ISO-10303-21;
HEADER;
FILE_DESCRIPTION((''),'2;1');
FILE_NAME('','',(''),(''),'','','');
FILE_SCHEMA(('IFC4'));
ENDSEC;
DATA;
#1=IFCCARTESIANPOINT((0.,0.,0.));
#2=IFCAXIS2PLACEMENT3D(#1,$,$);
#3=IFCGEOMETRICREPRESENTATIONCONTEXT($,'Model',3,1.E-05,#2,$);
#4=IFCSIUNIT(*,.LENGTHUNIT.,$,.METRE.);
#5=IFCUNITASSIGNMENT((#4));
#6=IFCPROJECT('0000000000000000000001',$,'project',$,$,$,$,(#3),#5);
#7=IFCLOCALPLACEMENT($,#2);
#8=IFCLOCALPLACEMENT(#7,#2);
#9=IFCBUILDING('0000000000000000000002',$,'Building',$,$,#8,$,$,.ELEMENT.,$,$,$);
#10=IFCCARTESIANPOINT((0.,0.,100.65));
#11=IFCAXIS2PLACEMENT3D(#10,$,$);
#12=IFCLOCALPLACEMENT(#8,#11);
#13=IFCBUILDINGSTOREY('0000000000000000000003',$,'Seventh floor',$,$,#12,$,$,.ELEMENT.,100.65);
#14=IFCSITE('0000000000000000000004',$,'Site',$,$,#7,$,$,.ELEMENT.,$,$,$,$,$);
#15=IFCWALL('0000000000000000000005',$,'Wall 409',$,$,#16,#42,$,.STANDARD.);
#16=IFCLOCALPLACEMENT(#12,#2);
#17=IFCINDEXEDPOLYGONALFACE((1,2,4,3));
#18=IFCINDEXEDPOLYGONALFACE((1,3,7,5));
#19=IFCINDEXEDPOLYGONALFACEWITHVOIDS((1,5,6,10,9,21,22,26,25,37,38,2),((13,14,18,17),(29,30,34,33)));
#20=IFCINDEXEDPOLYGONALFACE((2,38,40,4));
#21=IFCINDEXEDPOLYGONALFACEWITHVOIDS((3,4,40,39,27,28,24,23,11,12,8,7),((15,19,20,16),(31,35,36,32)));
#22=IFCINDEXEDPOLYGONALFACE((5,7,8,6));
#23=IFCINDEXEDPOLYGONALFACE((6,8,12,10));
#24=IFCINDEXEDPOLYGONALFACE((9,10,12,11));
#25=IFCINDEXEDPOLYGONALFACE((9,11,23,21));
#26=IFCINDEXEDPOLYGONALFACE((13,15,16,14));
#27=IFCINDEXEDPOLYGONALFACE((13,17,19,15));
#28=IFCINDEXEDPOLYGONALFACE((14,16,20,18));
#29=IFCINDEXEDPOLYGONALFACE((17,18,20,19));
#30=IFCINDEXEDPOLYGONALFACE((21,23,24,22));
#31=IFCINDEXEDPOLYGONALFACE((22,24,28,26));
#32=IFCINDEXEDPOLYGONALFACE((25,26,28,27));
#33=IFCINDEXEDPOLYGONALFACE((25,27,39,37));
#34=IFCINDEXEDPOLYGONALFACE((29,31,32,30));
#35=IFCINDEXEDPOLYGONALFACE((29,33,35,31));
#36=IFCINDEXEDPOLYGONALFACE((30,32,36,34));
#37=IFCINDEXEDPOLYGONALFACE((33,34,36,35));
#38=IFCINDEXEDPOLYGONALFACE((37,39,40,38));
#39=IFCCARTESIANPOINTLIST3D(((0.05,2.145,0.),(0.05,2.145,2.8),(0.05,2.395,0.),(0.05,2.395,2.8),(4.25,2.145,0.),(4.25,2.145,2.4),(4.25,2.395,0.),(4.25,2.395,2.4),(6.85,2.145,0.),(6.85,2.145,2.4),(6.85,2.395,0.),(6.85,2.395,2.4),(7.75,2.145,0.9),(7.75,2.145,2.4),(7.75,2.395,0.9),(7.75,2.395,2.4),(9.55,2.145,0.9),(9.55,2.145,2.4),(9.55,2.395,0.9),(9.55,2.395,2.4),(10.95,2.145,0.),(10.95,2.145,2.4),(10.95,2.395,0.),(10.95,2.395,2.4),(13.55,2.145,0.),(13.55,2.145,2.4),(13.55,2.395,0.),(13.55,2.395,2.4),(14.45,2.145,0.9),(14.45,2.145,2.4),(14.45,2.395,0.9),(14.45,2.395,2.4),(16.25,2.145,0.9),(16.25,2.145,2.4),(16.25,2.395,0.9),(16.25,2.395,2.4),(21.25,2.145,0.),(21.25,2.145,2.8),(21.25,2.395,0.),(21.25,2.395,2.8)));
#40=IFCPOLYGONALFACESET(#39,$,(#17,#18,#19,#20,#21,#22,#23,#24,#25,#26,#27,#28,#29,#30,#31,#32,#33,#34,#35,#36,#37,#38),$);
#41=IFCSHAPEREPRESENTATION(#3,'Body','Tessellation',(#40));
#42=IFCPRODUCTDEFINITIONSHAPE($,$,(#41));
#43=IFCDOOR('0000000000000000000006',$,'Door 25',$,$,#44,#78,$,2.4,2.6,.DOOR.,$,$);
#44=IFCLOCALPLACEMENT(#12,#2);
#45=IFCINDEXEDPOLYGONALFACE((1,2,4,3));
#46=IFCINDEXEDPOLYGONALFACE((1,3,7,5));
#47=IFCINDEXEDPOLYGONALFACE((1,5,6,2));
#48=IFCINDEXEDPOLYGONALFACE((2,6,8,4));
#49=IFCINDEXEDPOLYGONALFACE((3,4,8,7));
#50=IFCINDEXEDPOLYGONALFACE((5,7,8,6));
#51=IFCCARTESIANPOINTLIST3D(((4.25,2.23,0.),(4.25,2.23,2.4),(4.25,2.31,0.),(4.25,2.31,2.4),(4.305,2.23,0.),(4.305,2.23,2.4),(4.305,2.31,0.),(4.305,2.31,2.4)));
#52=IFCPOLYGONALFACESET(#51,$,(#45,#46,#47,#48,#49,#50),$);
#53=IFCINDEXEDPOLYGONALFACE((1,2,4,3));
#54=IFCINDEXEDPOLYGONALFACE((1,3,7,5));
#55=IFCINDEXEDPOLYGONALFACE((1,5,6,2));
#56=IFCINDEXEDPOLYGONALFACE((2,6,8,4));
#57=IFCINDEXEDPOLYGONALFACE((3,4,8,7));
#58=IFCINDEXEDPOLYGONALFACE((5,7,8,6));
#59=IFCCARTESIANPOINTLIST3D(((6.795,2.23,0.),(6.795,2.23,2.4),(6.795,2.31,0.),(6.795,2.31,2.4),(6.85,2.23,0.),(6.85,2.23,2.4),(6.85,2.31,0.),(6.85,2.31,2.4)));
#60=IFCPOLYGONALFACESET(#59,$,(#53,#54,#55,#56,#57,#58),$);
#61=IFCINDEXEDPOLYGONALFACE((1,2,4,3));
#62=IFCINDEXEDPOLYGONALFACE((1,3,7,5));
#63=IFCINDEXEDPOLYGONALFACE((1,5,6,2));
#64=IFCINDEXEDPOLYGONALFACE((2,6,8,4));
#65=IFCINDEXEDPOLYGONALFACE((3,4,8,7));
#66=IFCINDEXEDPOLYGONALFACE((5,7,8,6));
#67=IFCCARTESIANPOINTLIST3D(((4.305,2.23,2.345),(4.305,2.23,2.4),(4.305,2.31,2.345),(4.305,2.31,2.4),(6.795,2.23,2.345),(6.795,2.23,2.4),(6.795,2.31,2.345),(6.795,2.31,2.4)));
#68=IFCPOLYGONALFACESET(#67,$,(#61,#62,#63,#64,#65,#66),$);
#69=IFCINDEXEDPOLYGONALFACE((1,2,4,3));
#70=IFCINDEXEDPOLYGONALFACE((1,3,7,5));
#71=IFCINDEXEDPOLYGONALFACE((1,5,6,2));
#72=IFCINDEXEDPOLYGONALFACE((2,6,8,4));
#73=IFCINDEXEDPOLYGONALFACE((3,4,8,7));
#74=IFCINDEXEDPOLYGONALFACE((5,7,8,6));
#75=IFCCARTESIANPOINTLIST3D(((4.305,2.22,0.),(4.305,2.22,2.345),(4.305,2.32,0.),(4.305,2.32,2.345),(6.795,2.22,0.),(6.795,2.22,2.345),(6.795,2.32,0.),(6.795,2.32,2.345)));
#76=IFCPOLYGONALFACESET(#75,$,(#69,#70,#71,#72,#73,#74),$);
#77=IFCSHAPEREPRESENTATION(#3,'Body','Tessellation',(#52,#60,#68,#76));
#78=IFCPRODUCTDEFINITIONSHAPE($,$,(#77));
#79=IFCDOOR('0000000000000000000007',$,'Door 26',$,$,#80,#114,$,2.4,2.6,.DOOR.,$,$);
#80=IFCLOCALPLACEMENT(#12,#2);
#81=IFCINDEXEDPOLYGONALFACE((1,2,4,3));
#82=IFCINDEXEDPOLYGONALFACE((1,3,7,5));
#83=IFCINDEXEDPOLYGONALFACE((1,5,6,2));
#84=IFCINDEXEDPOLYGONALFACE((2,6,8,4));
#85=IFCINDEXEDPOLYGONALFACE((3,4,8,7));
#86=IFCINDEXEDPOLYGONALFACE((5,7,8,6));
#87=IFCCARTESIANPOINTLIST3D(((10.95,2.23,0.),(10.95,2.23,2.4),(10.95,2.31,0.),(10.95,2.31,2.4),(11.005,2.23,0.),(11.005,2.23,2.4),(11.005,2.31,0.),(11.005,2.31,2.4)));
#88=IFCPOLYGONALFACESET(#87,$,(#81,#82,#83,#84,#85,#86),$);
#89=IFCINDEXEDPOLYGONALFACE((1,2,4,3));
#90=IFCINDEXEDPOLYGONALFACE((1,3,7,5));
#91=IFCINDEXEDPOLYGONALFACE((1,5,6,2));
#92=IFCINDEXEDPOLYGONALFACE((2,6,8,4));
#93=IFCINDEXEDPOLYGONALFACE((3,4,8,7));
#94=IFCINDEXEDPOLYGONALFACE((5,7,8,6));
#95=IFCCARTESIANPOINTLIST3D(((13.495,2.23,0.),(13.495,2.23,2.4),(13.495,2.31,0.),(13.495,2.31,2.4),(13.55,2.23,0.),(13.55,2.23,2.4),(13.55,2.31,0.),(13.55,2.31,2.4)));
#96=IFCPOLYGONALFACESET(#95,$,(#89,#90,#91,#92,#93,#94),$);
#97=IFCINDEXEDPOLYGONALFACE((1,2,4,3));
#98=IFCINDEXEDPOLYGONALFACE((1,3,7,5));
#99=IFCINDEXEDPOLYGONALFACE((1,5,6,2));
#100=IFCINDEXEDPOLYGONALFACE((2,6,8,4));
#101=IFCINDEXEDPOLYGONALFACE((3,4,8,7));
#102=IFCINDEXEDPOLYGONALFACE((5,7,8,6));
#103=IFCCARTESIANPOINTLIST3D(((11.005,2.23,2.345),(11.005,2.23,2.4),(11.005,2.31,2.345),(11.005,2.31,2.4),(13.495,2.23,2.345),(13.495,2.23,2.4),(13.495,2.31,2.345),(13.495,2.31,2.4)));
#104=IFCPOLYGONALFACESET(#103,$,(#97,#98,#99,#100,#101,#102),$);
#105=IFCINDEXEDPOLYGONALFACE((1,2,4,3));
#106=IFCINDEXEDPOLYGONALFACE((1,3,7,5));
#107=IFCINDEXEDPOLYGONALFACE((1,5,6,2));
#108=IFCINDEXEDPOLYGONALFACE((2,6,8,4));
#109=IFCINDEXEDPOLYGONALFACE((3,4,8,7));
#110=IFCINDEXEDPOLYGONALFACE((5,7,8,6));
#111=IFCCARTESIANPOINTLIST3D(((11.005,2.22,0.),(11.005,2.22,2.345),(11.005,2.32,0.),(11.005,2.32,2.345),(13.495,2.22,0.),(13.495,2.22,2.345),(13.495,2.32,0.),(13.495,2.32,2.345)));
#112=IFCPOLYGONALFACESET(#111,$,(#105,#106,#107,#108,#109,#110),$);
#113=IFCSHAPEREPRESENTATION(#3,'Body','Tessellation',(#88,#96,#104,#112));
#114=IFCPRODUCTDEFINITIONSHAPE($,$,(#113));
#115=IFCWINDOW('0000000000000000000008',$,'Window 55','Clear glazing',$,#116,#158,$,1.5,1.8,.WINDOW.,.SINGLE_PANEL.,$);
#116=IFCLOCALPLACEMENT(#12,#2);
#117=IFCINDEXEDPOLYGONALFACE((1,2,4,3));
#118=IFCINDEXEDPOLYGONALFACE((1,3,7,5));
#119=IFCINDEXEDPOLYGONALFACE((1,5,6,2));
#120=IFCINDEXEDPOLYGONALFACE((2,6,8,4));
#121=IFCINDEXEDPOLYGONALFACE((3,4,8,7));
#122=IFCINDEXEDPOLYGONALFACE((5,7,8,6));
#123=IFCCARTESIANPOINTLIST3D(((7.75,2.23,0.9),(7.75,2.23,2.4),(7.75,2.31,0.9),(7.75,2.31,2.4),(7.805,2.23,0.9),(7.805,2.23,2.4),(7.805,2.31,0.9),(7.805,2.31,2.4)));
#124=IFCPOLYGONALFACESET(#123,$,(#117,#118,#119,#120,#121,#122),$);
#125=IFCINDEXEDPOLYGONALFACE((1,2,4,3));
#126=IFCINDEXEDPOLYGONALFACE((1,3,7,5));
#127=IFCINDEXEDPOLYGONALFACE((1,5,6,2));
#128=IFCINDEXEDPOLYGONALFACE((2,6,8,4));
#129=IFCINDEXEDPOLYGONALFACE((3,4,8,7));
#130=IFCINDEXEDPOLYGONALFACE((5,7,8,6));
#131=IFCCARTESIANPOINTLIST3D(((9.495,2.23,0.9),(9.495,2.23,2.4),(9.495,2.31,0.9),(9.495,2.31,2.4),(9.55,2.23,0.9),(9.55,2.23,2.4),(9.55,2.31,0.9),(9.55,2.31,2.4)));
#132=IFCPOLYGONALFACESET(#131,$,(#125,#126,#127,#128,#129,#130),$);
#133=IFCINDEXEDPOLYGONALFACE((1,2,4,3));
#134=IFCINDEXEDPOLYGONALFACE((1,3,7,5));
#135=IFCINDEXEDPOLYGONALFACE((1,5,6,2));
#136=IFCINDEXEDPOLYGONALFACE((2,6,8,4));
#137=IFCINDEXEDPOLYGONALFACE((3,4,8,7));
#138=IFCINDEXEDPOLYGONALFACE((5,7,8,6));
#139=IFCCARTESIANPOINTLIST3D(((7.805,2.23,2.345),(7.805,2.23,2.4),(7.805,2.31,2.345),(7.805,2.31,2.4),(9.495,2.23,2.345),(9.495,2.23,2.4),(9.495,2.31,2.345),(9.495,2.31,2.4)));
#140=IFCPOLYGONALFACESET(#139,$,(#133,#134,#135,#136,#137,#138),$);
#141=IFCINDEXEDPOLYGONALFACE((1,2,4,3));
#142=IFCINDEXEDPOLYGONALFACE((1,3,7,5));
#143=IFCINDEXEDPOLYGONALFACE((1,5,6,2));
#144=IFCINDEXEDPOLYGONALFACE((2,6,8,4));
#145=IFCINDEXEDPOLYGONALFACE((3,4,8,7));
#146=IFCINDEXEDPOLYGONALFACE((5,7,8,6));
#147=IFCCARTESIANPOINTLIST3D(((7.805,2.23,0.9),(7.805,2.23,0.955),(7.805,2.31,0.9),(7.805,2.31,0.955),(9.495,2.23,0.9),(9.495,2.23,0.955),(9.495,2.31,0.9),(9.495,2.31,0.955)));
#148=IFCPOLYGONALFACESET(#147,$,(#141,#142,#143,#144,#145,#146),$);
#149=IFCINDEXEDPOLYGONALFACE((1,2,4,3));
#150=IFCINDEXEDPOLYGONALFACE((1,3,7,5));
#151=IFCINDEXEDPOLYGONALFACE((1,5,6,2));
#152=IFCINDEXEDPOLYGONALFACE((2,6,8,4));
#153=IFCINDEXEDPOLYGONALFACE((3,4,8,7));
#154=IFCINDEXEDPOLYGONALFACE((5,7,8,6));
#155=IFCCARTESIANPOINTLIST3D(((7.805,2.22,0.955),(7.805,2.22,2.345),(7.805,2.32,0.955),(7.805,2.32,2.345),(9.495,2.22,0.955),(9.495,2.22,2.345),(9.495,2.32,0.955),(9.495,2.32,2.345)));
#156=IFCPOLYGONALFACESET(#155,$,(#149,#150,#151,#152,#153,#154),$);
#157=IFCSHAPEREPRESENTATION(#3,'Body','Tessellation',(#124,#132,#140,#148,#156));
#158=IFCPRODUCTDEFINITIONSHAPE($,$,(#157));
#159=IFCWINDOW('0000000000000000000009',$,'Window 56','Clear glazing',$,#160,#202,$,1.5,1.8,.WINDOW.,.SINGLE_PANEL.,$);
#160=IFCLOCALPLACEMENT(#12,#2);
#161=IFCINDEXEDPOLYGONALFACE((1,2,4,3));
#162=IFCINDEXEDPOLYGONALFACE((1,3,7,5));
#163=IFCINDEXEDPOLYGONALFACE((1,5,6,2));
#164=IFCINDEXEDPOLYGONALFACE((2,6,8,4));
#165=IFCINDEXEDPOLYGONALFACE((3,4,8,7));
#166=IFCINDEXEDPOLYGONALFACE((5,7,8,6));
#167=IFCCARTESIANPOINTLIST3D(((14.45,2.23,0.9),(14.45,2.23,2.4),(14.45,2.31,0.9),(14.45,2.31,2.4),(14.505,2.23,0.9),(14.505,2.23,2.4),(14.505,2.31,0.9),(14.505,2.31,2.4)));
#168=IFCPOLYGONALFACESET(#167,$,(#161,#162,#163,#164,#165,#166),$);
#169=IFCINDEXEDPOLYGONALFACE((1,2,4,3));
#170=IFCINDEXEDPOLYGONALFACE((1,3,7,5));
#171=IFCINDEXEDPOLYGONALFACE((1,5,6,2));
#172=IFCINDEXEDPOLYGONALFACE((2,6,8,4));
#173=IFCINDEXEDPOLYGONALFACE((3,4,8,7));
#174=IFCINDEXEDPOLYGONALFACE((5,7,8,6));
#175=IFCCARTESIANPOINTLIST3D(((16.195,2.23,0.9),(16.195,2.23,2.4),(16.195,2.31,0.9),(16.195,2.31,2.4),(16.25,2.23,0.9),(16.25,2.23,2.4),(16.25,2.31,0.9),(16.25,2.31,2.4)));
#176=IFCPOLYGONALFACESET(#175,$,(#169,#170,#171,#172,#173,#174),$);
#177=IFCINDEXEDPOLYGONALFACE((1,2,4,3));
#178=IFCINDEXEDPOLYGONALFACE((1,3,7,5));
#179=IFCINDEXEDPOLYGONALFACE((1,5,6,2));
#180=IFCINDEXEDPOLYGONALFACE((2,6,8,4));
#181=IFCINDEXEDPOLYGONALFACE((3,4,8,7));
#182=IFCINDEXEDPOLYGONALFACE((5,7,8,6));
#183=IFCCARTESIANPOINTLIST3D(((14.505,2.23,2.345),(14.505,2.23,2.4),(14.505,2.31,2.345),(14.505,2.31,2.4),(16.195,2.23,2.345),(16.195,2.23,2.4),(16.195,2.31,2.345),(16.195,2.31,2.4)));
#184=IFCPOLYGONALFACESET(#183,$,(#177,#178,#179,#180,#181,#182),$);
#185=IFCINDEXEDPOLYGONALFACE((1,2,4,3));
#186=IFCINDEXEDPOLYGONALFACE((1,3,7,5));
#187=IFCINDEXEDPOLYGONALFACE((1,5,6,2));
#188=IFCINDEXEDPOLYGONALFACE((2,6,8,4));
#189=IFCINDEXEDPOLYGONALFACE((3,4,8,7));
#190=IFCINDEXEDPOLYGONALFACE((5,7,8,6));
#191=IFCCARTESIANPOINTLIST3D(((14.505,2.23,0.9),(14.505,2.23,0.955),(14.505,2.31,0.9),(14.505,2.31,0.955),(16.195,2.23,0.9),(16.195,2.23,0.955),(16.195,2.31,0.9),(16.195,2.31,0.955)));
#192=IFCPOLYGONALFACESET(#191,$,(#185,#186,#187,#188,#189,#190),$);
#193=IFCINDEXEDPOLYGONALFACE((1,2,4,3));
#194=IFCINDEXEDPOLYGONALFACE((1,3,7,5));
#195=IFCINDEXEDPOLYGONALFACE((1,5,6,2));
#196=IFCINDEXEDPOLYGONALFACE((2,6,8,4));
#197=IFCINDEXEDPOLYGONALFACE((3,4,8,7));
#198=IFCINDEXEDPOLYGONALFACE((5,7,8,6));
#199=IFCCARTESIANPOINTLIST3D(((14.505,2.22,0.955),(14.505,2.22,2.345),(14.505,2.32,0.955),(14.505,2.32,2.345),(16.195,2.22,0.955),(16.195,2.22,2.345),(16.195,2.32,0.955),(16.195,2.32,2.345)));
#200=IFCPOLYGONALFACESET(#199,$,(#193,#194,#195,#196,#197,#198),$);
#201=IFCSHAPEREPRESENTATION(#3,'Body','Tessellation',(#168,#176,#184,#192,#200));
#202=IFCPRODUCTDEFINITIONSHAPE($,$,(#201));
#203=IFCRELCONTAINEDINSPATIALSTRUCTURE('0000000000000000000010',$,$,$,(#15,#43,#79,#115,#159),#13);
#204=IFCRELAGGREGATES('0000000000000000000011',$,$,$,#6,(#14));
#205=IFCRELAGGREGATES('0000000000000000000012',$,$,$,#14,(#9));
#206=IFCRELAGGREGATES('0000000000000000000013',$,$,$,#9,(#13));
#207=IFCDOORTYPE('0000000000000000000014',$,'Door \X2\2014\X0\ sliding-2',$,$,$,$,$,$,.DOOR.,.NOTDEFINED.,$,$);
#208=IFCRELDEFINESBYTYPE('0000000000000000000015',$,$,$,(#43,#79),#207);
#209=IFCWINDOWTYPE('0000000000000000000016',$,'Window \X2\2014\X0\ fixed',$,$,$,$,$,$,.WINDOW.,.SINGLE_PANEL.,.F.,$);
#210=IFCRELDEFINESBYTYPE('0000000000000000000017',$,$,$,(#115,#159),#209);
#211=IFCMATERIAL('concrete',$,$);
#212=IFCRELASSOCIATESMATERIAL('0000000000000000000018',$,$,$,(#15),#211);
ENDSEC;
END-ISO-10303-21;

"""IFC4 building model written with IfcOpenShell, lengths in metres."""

from ifc_helpers import new_model, si_unit, frame, frame_2d, origin, place, context, project, spatial, rectangle, extrude, material, type_object, element, fill, save


model = new_model("IFC4")

# Units and contexts
model_context = context("Model", 3, precision=1e-05, world=origin())
ifc_project = project(units=[si_unit("LENGTHUNIT", "METRE")], contexts=[model_context])

# Site, building, storey
site_placement = place(None, origin())
site = spatial("IfcSite", under=ifc_project, at=site_placement, Name="Site", CompositionType="ELEMENT")
building_placement = place(site_placement, origin())
building = spatial("IfcBuilding", under=site, at=building_placement, Name="Building", CompositionType="ELEMENT")
storey_placement = place(building_placement, frame((0.0, 0.0, 100.65)))
storey = spatial("IfcBuildingStorey", under=building, at=storey_placement, Name="Seventh floor", CompositionType="ELEMENT", Elevation=100.65)

# Shared definitions
ifc_material = material(Name="concrete")

# Wall, openings, doors, windows
wall_1_placement = place(storey_placement, frame((0.05, 2.27, 0.0), z_axis=(0.0, 0.0, 1.0), x_axis=(1.0, 0.0, 0.0)))
wall_1 = element("IfcWall", 1, at=wall_1_placement, inside=storey, material=ifc_material, Name="Wall 409", PredefinedType="STANDARD", context=model_context, shape_type="SweptSolid", body=[
    extrude(rectangle(XDim=21.2, YDim=0.25, at=frame_2d((10.6, 0.0))), origin(), (0.0, 0.0, 1.0), 2.8),
])
opening_1_placement = place(storey_placement, frame((4.25, 2.27, 0.0), z_axis=(0.0, 0.0, 1.0), x_axis=(1.0, 0.0, 0.0)))
opening_1 = element("IfcOpeningElement", 2, at=opening_1_placement, cuts=wall_1, PredefinedType="OPENING", context=model_context, shape_type="SweptSolid", body=[
    extrude(rectangle(XDim=2.6, YDim=0.31, at=frame_2d((1.3, 0.0))), origin(), (0.0, 0.0, 1.0), 2.4),
])
opening_2_placement = place(storey_placement, frame((7.75, 2.27, 0.9), z_axis=(0.0, 0.0, 1.0), x_axis=(1.0, 0.0, 0.0)))
opening_2 = element("IfcOpeningElement", 3, at=opening_2_placement, cuts=wall_1, PredefinedType="OPENING", context=model_context, shape_type="SweptSolid", body=[
    extrude(rectangle(XDim=1.8, YDim=0.31, at=frame_2d((0.9, 0.0))), origin(), (0.0, 0.0, 1.0), 1.5),
])
opening_3_placement = place(storey_placement, frame((10.95, 2.27, 0.0), z_axis=(0.0, 0.0, 1.0), x_axis=(1.0, 0.0, 0.0)))
opening_3 = element("IfcOpeningElement", 4, at=opening_3_placement, cuts=wall_1, PredefinedType="OPENING", context=model_context, shape_type="SweptSolid", body=[
    extrude(rectangle(XDim=2.6, YDim=0.31, at=frame_2d((1.3, 0.0))), origin(), (0.0, 0.0, 1.0), 2.4),
])
opening_4_placement = place(storey_placement, frame((14.45, 2.27, 0.9), z_axis=(0.0, 0.0, 1.0), x_axis=(1.0, 0.0, 0.0)))
opening_4 = element("IfcOpeningElement", 5, at=opening_4_placement, cuts=wall_1, PredefinedType="OPENING", context=model_context, shape_type="SweptSolid", body=[
    extrude(rectangle(XDim=1.8, YDim=0.31, at=frame_2d((0.9, 0.0))), origin(), (0.0, 0.0, 1.0), 1.5),
])
door_type = type_object("IfcDoorType", Name="Door — sliding-2", PredefinedType="DOOR")
door_1_placement = place(storey_placement, frame((4.25, 2.27, 0.0), z_axis=(0.0, 0.0, 1.0), x_axis=(1.0, 0.0, 0.0)))
door_1 = element("IfcDoor", 6, at=door_1_placement, inside=storey, type_object=door_type, Name="Door 25", OverallHeight=2.4, OverallWidth=2.6, PredefinedType="DOOR", context=model_context, shape_type="SweptSolid", body=[
    extrude(rectangle(XDim=0.055, YDim=0.08, at=frame_2d((0.0275, 0.0))), origin(), (0.0, 0.0, 1.0), 2.4),
    extrude(rectangle(XDim=0.055, YDim=0.08, at=frame_2d((2.5725, 0.0))), origin(), (0.0, 0.0, 1.0), 2.4),
    extrude(rectangle(XDim=2.49, YDim=0.08, at=frame_2d((1.3, 0.0))), frame((0.0, 0.0, 2.345)), (0.0, 0.0, 1.0), 0.055),
    extrude(rectangle(XDim=2.49, YDim=0.1, at=frame_2d((1.3, 0.0))), origin(), (0.0, 0.0, 1.0), 2.345),
])
fill(opening_1, door_1)
door_2_placement = place(storey_placement, frame((10.95, 2.27, 0.0), z_axis=(0.0, 0.0, 1.0), x_axis=(1.0, 0.0, 0.0)))
door_2 = element("IfcDoor", 7, at=door_2_placement, inside=storey, type_object=door_type, Name="Door 26", OverallHeight=2.4, OverallWidth=2.6, PredefinedType="DOOR", context=model_context, shape_type="SweptSolid", body=[
    extrude(rectangle(XDim=0.055, YDim=0.08, at=frame_2d((0.0275, 0.0))), origin(), (0.0, 0.0, 1.0), 2.4),
    extrude(rectangle(XDim=0.055, YDim=0.08, at=frame_2d((2.5725, 0.0))), origin(), (0.0, 0.0, 1.0), 2.4),
    extrude(rectangle(XDim=2.49, YDim=0.08, at=frame_2d((1.3, 0.0))), frame((0.0, 0.0, 2.345)), (0.0, 0.0, 1.0), 0.055),
    extrude(rectangle(XDim=2.49, YDim=0.1, at=frame_2d((1.3, 0.0))), origin(), (0.0, 0.0, 1.0), 2.345),
])
fill(opening_3, door_2)
window_type = type_object("IfcWindowType", Name="Window — fixed", ParameterTakesPrecedence=False, PartitioningType="SINGLE_PANEL", PredefinedType="WINDOW")
window_1_placement = place(storey_placement, frame((7.75, 2.27, 0.9), z_axis=(0.0, 0.0, 1.0), x_axis=(1.0, 0.0, 0.0)))
window_1 = element("IfcWindow", 8, at=window_1_placement, inside=storey, type_object=window_type, Name="Window 55", Description="Clear glazing", OverallHeight=1.5, OverallWidth=1.8, PartitioningType="SINGLE_PANEL", PredefinedType="WINDOW", context=model_context, shape_type="SweptSolid", body=[
    extrude(rectangle(XDim=0.055, YDim=0.08, at=frame_2d((0.0275, 0.0))), origin(), (0.0, 0.0, 1.0), 1.5),
    extrude(rectangle(XDim=0.055, YDim=0.08, at=frame_2d((1.7725, 0.0))), origin(), (0.0, 0.0, 1.0), 1.5),
    extrude(rectangle(XDim=1.69, YDim=0.08, at=frame_2d((0.9, 0.0))), frame((0.0, 0.0, 1.445)), (0.0, 0.0, 1.0), 0.055),
    extrude(rectangle(XDim=1.69, YDim=0.08, at=frame_2d((0.9, 0.0))), origin(), (0.0, 0.0, 1.0), 0.055),
    extrude(rectangle(XDim=1.69, YDim=0.1, at=frame_2d((0.9, 0.0))), frame((0.0, 0.0, 0.055)), (0.0, 0.0, 1.0), 1.39),
])
fill(opening_2, window_1)
window_2_placement = place(storey_placement, frame((14.45, 2.27, 0.9), z_axis=(0.0, 0.0, 1.0), x_axis=(1.0, 0.0, 0.0)))
window_2 = element("IfcWindow", 9, at=window_2_placement, inside=storey, type_object=window_type, Name="Window 56", Description="Clear glazing", OverallHeight=1.5, OverallWidth=1.8, PartitioningType="SINGLE_PANEL", PredefinedType="WINDOW", context=model_context, shape_type="SweptSolid", body=[
    extrude(rectangle(XDim=0.055, YDim=0.08, at=frame_2d((0.0275, 0.0))), origin(), (0.0, 0.0, 1.0), 1.5),
    extrude(rectangle(XDim=0.055, YDim=0.08, at=frame_2d((1.7725, 0.0))), origin(), (0.0, 0.0, 1.0), 1.5),
    extrude(rectangle(XDim=1.69, YDim=0.08, at=frame_2d((0.9, 0.0))), frame((0.0, 0.0, 1.445)), (0.0, 0.0, 1.0), 0.055),
    extrude(rectangle(XDim=1.69, YDim=0.08, at=frame_2d((0.9, 0.0))), origin(), (0.0, 0.0, 1.0), 0.055),
    extrude(rectangle(XDim=1.69, YDim=0.1, at=frame_2d((0.9, 0.0))), frame((0.0, 0.0, 0.055)), (0.0, 0.0, 1.0), 1.39),
])
fill(opening_4, window_2)

save(model, "model.ifc")
